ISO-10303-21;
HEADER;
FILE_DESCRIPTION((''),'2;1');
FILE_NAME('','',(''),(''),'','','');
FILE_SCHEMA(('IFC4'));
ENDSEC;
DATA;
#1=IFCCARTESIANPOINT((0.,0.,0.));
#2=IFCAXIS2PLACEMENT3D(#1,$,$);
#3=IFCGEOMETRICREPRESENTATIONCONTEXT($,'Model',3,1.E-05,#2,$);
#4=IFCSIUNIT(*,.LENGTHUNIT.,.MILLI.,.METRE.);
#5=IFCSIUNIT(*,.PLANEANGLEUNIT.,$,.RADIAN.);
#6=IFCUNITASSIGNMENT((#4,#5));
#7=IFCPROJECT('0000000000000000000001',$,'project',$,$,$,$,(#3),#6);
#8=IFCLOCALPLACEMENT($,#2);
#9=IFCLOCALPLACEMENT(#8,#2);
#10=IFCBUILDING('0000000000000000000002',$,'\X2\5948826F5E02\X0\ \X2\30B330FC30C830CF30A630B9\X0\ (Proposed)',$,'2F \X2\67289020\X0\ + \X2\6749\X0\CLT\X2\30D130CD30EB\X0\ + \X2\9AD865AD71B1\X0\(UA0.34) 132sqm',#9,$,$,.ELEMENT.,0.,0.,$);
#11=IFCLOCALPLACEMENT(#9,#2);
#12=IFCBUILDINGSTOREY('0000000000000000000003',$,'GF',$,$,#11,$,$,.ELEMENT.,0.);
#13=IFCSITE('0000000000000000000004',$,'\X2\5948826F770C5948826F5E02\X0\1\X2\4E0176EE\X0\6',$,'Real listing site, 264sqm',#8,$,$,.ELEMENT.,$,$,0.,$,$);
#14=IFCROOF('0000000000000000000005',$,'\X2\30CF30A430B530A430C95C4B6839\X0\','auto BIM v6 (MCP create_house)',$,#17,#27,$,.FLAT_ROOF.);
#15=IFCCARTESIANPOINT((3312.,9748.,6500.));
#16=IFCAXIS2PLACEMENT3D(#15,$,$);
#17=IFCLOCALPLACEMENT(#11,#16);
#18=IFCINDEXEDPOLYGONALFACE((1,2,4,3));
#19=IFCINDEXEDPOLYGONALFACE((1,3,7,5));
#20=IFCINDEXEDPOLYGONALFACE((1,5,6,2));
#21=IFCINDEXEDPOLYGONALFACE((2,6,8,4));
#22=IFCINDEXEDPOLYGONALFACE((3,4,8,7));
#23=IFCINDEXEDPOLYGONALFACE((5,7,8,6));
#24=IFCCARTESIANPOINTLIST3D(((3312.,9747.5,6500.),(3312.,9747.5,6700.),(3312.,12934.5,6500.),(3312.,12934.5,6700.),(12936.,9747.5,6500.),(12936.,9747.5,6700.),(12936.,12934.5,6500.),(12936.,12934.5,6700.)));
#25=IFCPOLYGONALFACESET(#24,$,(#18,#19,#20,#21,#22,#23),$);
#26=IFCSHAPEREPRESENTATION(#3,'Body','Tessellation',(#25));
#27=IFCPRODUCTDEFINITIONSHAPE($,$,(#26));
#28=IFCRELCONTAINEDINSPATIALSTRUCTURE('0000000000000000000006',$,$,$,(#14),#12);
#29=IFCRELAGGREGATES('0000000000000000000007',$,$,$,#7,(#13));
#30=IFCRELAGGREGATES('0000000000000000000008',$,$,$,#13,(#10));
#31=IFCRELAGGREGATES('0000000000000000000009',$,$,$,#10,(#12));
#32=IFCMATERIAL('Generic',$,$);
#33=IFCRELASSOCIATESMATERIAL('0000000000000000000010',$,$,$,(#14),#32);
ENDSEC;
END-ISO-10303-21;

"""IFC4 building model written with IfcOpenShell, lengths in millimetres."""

from ifc_helpers import new_model, si_unit, frame, frame_2d, origin, place, context, project, spatial, rectangle, extrude, material, element, save


model = new_model("IFC4")

# Units and contexts
model_context = context("Model", 3, precision=1e-05, world=origin())
ifc_project = project(units=[si_unit("LENGTHUNIT", "METRE", prefix="MILLI"), si_unit("PLANEANGLEUNIT", "RADIAN")], contexts=[model_context])

# Site, building, storey
site_placement = place(None, origin())
site = spatial("IfcSite", under=ifc_project, at=site_placement, Name="奈良県奈良市1丁目6", ObjectType="Real listing site, 264sqm", CompositionType="ELEMENT", RefElevation=0.0)
building_placement = place(site_placement, origin())
building = spatial("IfcBuilding", under=site, at=building_placement, Name="奈良市 コートハウス (Proposed)", ObjectType="2F 木造 + 杉CLTパネル + 高断熱(UA0.34) 132sqm", CompositionType="ELEMENT", ElevationOfRefHeight=0.0, ElevationOfTerrain=0.0)
storey_placement = place(building_placement, origin())
storey = spatial("IfcBuildingStorey", under=building, at=storey_placement, Name="GF", CompositionType="ELEMENT", Elevation=0.0)

# Shared definitions
ifc_material = material(Name="Generic")

# Roof
roof_placement = place(storey_placement, frame((3312.0, 9748.0, 6500.0)))
element("IfcRoof", 1, at=roof_placement, inside=storey, material=ifc_material, Name="ハイサイド屋根", Description="auto BIM v6 (MCP create_house)", PredefinedType="FLAT_ROOF", context=model_context, shape_type="SweptSolid", body=[
    extrude(rectangle(XDim=9624.0, YDim=3187.0, at=frame_2d((4812.0, 1593.0))), frame((3312.0, 9748.0, 6500.0)), (0.0, 0.0, 1.0), 200.0),
])

save(model, "model.ifc")
